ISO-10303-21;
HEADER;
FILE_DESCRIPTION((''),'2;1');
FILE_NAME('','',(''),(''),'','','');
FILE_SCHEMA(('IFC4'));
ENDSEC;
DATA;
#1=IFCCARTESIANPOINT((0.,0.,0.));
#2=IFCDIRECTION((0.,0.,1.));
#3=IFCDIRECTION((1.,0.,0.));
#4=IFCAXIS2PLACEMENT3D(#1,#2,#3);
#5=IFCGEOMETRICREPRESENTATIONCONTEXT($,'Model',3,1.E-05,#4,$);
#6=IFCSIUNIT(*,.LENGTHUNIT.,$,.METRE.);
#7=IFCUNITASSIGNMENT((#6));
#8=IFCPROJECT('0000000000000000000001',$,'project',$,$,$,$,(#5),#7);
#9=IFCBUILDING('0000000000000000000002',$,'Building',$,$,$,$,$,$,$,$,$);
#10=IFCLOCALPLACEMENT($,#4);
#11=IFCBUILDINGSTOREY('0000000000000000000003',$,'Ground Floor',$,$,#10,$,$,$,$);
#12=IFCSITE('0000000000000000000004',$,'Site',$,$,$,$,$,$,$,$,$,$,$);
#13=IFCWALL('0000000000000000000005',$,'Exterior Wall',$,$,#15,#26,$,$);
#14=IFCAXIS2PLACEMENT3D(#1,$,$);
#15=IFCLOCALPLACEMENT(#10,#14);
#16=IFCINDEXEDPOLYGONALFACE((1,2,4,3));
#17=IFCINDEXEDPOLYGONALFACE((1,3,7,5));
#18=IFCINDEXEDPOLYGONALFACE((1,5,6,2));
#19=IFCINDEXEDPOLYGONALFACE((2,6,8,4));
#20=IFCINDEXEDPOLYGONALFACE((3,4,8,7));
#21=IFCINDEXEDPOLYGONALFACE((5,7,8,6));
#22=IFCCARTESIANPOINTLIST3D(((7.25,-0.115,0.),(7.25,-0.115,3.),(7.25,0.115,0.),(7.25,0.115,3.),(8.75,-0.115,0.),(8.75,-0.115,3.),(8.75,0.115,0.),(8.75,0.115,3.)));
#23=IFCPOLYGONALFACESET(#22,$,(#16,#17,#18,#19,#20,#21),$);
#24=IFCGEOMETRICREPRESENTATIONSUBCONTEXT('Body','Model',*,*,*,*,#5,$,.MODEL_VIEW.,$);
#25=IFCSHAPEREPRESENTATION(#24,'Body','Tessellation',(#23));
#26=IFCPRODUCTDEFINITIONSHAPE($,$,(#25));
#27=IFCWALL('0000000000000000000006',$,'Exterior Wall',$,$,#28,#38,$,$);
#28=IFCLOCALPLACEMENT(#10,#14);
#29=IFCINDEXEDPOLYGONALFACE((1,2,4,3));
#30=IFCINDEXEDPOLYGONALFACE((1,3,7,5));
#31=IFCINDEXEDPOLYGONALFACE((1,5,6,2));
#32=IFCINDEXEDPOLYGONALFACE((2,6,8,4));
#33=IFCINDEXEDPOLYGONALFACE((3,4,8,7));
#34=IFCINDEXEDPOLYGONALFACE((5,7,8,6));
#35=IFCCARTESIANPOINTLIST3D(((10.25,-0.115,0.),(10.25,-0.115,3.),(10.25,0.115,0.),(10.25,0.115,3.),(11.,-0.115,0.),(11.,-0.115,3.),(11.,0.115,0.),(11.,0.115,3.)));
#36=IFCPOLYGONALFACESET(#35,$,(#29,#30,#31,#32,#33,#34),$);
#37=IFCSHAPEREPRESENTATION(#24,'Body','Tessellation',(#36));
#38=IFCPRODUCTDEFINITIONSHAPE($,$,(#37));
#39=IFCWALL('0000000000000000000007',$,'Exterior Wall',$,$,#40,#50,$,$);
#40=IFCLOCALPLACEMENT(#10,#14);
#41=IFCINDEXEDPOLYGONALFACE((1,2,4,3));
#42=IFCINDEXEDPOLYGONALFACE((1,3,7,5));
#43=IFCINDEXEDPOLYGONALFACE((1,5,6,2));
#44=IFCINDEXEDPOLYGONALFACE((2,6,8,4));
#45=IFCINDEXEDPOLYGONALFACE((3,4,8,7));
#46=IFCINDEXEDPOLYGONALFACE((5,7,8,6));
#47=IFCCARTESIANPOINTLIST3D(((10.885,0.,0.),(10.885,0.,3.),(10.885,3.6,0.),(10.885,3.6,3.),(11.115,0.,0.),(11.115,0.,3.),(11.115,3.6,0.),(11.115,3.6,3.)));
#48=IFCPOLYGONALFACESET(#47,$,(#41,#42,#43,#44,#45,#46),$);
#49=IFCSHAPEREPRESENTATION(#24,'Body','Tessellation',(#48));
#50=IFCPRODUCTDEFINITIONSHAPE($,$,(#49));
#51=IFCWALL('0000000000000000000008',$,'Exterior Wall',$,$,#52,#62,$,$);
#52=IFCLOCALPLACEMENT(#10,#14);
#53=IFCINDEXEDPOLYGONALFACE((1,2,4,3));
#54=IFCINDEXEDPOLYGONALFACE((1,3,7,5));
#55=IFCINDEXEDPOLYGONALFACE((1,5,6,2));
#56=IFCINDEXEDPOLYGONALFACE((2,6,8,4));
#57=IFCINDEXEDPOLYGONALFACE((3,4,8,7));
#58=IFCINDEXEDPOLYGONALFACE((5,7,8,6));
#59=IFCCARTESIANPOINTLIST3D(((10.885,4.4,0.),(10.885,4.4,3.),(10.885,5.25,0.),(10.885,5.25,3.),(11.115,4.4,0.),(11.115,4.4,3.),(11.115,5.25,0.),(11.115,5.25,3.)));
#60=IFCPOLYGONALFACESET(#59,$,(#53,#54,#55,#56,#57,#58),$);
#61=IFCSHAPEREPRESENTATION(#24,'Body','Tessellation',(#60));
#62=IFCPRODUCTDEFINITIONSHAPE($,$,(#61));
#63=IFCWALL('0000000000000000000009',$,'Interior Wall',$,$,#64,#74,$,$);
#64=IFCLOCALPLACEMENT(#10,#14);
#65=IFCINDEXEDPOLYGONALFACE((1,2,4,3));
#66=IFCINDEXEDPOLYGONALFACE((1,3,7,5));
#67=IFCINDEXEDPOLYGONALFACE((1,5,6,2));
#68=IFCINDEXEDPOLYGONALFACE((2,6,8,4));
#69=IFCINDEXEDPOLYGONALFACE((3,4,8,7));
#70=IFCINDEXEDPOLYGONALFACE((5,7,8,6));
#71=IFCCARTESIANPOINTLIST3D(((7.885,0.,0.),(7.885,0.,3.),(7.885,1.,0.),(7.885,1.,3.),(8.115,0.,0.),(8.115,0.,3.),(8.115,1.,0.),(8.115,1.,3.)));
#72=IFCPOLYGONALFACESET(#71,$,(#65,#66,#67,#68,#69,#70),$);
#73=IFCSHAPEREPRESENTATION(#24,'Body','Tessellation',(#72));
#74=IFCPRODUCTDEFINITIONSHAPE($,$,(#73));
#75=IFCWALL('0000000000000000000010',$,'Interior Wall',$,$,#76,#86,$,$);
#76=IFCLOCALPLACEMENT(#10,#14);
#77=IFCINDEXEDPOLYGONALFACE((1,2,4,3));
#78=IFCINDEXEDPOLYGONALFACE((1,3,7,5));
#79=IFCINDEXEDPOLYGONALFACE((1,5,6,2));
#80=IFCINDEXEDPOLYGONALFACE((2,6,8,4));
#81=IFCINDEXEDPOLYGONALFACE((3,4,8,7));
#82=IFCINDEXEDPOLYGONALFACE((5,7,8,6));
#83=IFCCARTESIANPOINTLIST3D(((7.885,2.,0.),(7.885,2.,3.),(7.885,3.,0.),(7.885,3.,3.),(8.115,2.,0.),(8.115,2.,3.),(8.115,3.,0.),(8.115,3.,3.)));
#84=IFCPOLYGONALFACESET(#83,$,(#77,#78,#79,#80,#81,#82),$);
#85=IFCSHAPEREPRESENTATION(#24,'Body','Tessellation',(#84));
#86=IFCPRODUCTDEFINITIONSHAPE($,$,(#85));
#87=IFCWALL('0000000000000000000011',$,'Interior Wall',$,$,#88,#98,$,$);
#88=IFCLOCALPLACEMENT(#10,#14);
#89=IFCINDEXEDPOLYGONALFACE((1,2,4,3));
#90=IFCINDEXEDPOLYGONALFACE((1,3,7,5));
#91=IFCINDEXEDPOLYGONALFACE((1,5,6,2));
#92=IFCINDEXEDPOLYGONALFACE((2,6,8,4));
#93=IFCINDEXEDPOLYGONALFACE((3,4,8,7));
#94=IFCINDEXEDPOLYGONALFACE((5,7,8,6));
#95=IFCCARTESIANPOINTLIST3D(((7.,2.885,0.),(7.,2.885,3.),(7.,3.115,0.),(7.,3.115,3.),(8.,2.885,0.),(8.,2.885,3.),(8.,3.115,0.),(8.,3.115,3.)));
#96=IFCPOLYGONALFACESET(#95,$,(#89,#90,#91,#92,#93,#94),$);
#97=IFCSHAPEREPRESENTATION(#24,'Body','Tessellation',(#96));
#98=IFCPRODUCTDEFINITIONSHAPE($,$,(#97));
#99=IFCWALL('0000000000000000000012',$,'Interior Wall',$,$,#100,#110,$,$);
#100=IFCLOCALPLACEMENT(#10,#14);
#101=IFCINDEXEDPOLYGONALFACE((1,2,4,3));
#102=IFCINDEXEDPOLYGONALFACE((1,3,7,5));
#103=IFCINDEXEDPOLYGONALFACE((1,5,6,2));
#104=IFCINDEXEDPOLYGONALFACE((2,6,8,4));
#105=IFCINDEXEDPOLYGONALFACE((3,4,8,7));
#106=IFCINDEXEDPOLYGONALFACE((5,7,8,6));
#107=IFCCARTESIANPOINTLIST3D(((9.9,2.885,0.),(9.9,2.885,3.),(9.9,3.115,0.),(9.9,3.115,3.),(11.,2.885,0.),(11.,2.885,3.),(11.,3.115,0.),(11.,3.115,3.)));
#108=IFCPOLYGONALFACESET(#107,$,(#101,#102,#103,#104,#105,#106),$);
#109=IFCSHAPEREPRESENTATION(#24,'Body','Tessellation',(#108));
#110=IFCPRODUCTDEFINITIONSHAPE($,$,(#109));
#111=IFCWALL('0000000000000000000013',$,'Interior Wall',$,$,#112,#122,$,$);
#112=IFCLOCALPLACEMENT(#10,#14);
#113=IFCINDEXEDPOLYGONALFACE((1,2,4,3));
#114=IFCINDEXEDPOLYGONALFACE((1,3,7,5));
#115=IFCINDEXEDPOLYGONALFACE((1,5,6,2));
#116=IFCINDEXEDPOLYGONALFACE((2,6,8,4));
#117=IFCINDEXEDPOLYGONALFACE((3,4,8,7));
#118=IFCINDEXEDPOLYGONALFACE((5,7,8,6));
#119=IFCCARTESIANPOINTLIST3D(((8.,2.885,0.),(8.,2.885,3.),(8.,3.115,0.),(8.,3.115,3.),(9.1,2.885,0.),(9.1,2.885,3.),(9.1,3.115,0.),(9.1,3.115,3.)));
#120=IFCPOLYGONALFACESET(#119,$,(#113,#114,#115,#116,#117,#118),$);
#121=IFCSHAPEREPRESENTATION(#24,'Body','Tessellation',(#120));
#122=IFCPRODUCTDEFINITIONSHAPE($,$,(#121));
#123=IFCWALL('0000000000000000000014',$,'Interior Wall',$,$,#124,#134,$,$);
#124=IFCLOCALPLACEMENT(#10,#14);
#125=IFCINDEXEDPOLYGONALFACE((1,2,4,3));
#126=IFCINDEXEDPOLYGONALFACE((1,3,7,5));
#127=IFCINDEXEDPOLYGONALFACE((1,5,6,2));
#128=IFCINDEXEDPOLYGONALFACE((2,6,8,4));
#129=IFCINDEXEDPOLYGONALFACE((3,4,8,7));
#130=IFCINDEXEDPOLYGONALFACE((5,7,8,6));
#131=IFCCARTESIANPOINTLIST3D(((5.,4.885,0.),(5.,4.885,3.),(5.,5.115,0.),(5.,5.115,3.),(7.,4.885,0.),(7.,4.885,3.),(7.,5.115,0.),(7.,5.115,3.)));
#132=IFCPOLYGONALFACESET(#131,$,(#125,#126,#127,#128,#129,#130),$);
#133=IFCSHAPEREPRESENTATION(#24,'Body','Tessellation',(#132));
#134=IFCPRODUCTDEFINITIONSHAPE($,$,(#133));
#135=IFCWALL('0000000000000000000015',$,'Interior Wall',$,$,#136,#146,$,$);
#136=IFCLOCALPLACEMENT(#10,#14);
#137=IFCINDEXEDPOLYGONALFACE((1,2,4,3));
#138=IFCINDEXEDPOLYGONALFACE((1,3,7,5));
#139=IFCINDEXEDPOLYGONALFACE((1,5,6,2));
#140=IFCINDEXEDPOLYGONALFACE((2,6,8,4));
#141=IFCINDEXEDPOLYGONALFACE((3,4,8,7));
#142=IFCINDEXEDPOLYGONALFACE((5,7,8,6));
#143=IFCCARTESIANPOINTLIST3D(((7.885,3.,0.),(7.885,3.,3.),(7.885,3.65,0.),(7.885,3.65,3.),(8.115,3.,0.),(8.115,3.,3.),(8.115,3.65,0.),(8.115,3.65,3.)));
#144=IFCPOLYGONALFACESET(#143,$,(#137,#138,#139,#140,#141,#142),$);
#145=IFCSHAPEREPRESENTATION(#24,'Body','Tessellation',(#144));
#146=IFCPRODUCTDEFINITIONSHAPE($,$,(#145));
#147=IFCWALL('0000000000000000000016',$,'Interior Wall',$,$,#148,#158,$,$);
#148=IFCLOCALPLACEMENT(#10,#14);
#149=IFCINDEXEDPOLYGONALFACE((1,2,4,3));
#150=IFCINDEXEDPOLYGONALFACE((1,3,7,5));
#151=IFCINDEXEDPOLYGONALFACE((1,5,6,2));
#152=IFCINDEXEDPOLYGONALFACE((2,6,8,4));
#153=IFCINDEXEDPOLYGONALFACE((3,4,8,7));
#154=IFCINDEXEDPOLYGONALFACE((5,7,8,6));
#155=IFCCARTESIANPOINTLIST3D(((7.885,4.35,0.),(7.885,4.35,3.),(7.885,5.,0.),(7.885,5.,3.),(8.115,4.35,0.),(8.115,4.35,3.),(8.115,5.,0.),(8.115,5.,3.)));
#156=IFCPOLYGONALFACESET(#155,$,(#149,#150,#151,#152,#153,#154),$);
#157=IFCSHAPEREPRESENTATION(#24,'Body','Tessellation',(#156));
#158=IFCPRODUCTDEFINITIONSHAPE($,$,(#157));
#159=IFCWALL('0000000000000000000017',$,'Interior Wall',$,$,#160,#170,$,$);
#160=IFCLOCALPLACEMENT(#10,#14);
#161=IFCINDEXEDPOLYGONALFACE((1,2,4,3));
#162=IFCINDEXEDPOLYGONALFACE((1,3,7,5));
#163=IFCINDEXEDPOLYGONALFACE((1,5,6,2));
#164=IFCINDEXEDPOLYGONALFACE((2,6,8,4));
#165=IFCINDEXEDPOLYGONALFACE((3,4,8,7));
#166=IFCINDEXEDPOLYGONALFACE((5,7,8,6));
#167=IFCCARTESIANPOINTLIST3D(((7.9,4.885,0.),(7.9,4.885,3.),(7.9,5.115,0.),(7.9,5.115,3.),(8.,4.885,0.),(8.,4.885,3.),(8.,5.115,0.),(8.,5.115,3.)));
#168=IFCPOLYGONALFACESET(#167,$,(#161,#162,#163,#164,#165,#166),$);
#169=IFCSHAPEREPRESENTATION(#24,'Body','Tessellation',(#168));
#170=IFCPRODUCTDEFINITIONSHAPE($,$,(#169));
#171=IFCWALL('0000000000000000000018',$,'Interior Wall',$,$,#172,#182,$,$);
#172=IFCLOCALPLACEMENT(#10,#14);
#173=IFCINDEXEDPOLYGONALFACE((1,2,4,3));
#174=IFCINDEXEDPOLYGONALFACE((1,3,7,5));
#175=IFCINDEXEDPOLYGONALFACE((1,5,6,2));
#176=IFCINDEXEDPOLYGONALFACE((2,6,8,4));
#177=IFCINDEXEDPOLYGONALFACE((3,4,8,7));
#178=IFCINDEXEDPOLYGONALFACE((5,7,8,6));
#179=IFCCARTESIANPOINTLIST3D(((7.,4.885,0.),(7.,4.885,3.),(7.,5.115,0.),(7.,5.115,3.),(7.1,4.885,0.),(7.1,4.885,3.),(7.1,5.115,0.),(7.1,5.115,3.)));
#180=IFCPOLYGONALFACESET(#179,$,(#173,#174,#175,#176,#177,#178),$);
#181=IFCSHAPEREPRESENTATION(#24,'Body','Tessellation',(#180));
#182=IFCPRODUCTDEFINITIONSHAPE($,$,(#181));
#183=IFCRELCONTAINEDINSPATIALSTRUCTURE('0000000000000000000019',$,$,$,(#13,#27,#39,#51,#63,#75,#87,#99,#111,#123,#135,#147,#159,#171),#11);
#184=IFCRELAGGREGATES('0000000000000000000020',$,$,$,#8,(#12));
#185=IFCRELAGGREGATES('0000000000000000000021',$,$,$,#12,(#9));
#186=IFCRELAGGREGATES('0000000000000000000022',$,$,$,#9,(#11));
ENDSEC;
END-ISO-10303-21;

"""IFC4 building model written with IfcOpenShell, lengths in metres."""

from ifc_helpers import new_model, si_unit, frame, origin_with_axes, place, context, subcontext, project, spatial, indexed_curve, outline, extrude, element, save


model = new_model("IFC4")

# Units and contexts
model_context = context("Model", 3, precision=1e-05, world=origin_with_axes())
body_context = subcontext(model_context, "Body", "Model", "MODEL_VIEW")
ifc_project = project(units=[si_unit("LENGTHUNIT", "METRE")], contexts=[model_context])

# Site, building, storey
site = spatial("IfcSite", under=ifc_project, Name="Site")
building = spatial("IfcBuilding", under=site, Name="Building")
storey_placement = place(None, origin_with_axes())
storey = spatial("IfcBuildingStorey", under=building, at=storey_placement, Name="Ground Floor")

# Walls
wall_1_placement = place(storey_placement, frame((7.25, 0.0, 0.0), z_axis=(0.0, 0.0, 1.0), x_axis=(1.0, 0.0, 0.0)))
element("IfcWall", 1, at=wall_1_placement, inside=storey, Name="Exterior Wall", context=body_context, shape_type="SweptSolid", body=[
    extrude(outline(indexed_curve([(0.0, 0.0), (0.0, 0.23), (1.5, 0.23), (1.5, 0.0), (0.0, 0.0)], self_intersect=False)), frame((0.0, -0.115, 0.0), z_axis=(0.0, 0.0, 1.0), x_axis=(1.0, 0.0, 0.0)), (0.0, 0.0, 1.0), 3.0),
])
wall_2_placement = place(storey_placement, frame((10.25, 0.0, 0.0), z_axis=(0.0, 0.0, 1.0), x_axis=(1.0, 0.0, 0.0)))
element("IfcWall", 2, at=wall_2_placement, inside=storey, Name="Exterior Wall", context=body_context, shape_type="SweptSolid", body=[
    extrude(outline(indexed_curve([(0.0, 0.0), (0.0, 0.23), (0.75, 0.23), (0.75, 0.0), (0.0, 0.0)], self_intersect=False)), frame((0.0, -0.115, 0.0), z_axis=(0.0, 0.0, 1.0), x_axis=(1.0, 0.0, 0.0)), (0.0, 0.0, 1.0), 3.0),
])
wall_3_placement = place(storey_placement, frame((11.0, 0.0, 0.0), z_axis=(0.0, 0.0, 1.0), x_axis=(0.0, 1.0, 0.0)))
element("IfcWall", 3, at=wall_3_placement, inside=storey, Name="Exterior Wall", context=body_context, shape_type="SweptSolid", body=[
    extrude(outline(indexed_curve([(0.0, 0.0), (0.0, 0.23), (3.6, 0.23), (3.6, 0.0), (0.0, 0.0)], self_intersect=False)), frame((0.0, -0.115, 0.0), z_axis=(0.0, 0.0, 1.0), x_axis=(1.0, 0.0, 0.0)), (0.0, 0.0, 1.0), 3.0),
])
wall_4_placement = place(storey_placement, frame((11.0, 4.4, 0.0), z_axis=(0.0, 0.0, 1.0), x_axis=(0.0, 1.0, 0.0)))
element("IfcWall", 4, at=wall_4_placement, inside=storey, Name="Exterior Wall", context=body_context, shape_type="SweptSolid", body=[
    extrude(outline(indexed_curve([(0.0, 0.0), (0.0, 0.23), (0.85, 0.23), (0.85, 0.0), (0.0, 0.0)], self_intersect=False)), frame((0.0, -0.115, 0.0), z_axis=(0.0, 0.0, 1.0), x_axis=(1.0, 0.0, 0.0)), (0.0, 0.0, 1.0), 3.0),
])
for number, where, z_axis, x_axis, name in (
    (5, (8.0, 0.0, 0.0), (0.0, 0.0, 1.0), (0.0, 1.0, 0.0), "Interior Wall"),
    (6, (8.0, 2.0, 0.0), (0.0, 0.0, 1.0), (0.0, 1.0, 0.0), "Interior Wall"),
    (7, (8.0, 3.0, 0.0), (0.0, 0.0, 1.0), (-1.0, 0.0, 0.0), "Interior Wall"),
):
    element("IfcWall", number, at=place(storey_placement, frame(where, z_axis=z_axis, x_axis=x_axis)), inside=storey, Name=name, context=body_context, shape_type="SweptSolid", body=[
        extrude(outline(indexed_curve([(0.0, 0.0), (0.0, 0.23), (1.0, 0.23), (1.0, 0.0), (0.0, 0.0)], self_intersect=False)), frame((0.0, -0.115, 0.0), z_axis=(0.0, 0.0, 1.0), x_axis=(1.0, 0.0, 0.0)), (0.0, 0.0, 1.0), 3.0),
    ])
for number, where, z_axis, x_axis, name in (
    (8, (11.0, 3.0, 0.0), (0.0, 0.0, 1.0), (-1.0, 0.0, 0.0), "Interior Wall"),
    (9, (9.1, 3.0, 0.0), (0.0, 0.0, 1.0), (-1.0, 0.0, 0.0), "Interior Wall"),
):
    element("IfcWall", number, at=place(storey_placement, frame(where, z_axis=z_axis, x_axis=x_axis)), inside=storey, Name=name, context=body_context, shape_type="SweptSolid", body=[
        extrude(outline(indexed_curve([(0.0, 0.0), (0.0, 0.23), (1.1, 0.23), (1.1, 0.0), (0.0, 0.0)], self_intersect=False)), frame((0.0, -0.115, 0.0), z_axis=(0.0, 0.0, 1.0), x_axis=(1.0, 0.0, 0.0)), (0.0, 0.0, 1.0), 3.0),
    ])
wall_5_placement = place(storey_placement, frame((7.0, 5.0, 0.0), z_axis=(0.0, 0.0, 1.0), x_axis=(-1.0, 0.0, 0.0)))
element("IfcWall", 10, at=wall_5_placement, inside=storey, Name="Interior Wall", context=body_context, shape_type="SweptSolid", body=[
    extrude(outline(indexed_curve([(0.0, 0.0), (0.0, 0.23), (2.0, 0.23), (2.0, 0.0), (0.0, 0.0)], self_intersect=False)), frame((0.0, -0.115, 0.0), z_axis=(0.0, 0.0, 1.0), x_axis=(1.0, 0.0, 0.0)), (0.0, 0.0, 1.0), 3.0),
])
wall_6_placement = place(storey_placement, frame((8.0, 3.0, 0.0), z_axis=(0.0, 0.0, 1.0), x_axis=(0.0, 1.0, 0.0)))
element("IfcWall", 11, at=wall_6_placement, inside=storey, Name="Interior Wall", context=body_context, shape_type="SweptSolid", body=[
    extrude(outline(indexed_curve([(0.0, 0.0), (0.0, 0.23), (0.65, 0.23), (0.65, 0.0), (0.0, 0.0)], self_intersect=False)), frame((0.0, -0.115, 0.0), z_axis=(0.0, 0.0, 1.0), x_axis=(1.0, 0.0, 0.0)), (0.0, 0.0, 1.0), 3.0),
])
wall_7_placement = place(storey_placement, frame((8.0, 4.35, 0.0), z_axis=(0.0, 0.0, 1.0), x_axis=(0.0, 1.0, 0.0)))
element("IfcWall", 12, at=wall_7_placement, inside=storey, Name="Interior Wall", context=body_context, shape_type="SweptSolid", body=[
    extrude(outline(indexed_curve([(0.0, 0.0), (0.0, 0.23), (0.65, 0.23), (0.65, 0.0), (0.0, 0.0)], self_intersect=False)), frame((0.0, -0.115, 0.0), z_axis=(0.0, 0.0, 1.0), x_axis=(1.0, 0.0, 0.0)), (0.0, 0.0, 1.0), 3.0),
])
for number, where, z_axis, x_axis, name in (
    (13, (8.0, 5.0, 0.0), (0.0, 0.0, 1.0), (-1.0, 0.0, 0.0), "Interior Wall"),
    (14, (7.1, 5.0, 0.0), (0.0, 0.0, 1.0), (-1.0, 0.0, 0.0), "Interior Wall"),
):
    element("IfcWall", number, at=place(storey_placement, frame(where, z_axis=z_axis, x_axis=x_axis)), inside=storey, Name=name, context=body_context, shape_type="SweptSolid", body=[
        extrude(outline(indexed_curve([(0.0, 0.0), (0.0, 0.23), (0.1, 0.23), (0.1, 0.0), (0.0, 0.0)], self_intersect=False)), frame((0.0, -0.115, 0.0), z_axis=(0.0, 0.0, 1.0), x_axis=(1.0, 0.0, 0.0)), (0.0, 0.0, 1.0), 3.0),
    ])

save(model, "model.ifc")
